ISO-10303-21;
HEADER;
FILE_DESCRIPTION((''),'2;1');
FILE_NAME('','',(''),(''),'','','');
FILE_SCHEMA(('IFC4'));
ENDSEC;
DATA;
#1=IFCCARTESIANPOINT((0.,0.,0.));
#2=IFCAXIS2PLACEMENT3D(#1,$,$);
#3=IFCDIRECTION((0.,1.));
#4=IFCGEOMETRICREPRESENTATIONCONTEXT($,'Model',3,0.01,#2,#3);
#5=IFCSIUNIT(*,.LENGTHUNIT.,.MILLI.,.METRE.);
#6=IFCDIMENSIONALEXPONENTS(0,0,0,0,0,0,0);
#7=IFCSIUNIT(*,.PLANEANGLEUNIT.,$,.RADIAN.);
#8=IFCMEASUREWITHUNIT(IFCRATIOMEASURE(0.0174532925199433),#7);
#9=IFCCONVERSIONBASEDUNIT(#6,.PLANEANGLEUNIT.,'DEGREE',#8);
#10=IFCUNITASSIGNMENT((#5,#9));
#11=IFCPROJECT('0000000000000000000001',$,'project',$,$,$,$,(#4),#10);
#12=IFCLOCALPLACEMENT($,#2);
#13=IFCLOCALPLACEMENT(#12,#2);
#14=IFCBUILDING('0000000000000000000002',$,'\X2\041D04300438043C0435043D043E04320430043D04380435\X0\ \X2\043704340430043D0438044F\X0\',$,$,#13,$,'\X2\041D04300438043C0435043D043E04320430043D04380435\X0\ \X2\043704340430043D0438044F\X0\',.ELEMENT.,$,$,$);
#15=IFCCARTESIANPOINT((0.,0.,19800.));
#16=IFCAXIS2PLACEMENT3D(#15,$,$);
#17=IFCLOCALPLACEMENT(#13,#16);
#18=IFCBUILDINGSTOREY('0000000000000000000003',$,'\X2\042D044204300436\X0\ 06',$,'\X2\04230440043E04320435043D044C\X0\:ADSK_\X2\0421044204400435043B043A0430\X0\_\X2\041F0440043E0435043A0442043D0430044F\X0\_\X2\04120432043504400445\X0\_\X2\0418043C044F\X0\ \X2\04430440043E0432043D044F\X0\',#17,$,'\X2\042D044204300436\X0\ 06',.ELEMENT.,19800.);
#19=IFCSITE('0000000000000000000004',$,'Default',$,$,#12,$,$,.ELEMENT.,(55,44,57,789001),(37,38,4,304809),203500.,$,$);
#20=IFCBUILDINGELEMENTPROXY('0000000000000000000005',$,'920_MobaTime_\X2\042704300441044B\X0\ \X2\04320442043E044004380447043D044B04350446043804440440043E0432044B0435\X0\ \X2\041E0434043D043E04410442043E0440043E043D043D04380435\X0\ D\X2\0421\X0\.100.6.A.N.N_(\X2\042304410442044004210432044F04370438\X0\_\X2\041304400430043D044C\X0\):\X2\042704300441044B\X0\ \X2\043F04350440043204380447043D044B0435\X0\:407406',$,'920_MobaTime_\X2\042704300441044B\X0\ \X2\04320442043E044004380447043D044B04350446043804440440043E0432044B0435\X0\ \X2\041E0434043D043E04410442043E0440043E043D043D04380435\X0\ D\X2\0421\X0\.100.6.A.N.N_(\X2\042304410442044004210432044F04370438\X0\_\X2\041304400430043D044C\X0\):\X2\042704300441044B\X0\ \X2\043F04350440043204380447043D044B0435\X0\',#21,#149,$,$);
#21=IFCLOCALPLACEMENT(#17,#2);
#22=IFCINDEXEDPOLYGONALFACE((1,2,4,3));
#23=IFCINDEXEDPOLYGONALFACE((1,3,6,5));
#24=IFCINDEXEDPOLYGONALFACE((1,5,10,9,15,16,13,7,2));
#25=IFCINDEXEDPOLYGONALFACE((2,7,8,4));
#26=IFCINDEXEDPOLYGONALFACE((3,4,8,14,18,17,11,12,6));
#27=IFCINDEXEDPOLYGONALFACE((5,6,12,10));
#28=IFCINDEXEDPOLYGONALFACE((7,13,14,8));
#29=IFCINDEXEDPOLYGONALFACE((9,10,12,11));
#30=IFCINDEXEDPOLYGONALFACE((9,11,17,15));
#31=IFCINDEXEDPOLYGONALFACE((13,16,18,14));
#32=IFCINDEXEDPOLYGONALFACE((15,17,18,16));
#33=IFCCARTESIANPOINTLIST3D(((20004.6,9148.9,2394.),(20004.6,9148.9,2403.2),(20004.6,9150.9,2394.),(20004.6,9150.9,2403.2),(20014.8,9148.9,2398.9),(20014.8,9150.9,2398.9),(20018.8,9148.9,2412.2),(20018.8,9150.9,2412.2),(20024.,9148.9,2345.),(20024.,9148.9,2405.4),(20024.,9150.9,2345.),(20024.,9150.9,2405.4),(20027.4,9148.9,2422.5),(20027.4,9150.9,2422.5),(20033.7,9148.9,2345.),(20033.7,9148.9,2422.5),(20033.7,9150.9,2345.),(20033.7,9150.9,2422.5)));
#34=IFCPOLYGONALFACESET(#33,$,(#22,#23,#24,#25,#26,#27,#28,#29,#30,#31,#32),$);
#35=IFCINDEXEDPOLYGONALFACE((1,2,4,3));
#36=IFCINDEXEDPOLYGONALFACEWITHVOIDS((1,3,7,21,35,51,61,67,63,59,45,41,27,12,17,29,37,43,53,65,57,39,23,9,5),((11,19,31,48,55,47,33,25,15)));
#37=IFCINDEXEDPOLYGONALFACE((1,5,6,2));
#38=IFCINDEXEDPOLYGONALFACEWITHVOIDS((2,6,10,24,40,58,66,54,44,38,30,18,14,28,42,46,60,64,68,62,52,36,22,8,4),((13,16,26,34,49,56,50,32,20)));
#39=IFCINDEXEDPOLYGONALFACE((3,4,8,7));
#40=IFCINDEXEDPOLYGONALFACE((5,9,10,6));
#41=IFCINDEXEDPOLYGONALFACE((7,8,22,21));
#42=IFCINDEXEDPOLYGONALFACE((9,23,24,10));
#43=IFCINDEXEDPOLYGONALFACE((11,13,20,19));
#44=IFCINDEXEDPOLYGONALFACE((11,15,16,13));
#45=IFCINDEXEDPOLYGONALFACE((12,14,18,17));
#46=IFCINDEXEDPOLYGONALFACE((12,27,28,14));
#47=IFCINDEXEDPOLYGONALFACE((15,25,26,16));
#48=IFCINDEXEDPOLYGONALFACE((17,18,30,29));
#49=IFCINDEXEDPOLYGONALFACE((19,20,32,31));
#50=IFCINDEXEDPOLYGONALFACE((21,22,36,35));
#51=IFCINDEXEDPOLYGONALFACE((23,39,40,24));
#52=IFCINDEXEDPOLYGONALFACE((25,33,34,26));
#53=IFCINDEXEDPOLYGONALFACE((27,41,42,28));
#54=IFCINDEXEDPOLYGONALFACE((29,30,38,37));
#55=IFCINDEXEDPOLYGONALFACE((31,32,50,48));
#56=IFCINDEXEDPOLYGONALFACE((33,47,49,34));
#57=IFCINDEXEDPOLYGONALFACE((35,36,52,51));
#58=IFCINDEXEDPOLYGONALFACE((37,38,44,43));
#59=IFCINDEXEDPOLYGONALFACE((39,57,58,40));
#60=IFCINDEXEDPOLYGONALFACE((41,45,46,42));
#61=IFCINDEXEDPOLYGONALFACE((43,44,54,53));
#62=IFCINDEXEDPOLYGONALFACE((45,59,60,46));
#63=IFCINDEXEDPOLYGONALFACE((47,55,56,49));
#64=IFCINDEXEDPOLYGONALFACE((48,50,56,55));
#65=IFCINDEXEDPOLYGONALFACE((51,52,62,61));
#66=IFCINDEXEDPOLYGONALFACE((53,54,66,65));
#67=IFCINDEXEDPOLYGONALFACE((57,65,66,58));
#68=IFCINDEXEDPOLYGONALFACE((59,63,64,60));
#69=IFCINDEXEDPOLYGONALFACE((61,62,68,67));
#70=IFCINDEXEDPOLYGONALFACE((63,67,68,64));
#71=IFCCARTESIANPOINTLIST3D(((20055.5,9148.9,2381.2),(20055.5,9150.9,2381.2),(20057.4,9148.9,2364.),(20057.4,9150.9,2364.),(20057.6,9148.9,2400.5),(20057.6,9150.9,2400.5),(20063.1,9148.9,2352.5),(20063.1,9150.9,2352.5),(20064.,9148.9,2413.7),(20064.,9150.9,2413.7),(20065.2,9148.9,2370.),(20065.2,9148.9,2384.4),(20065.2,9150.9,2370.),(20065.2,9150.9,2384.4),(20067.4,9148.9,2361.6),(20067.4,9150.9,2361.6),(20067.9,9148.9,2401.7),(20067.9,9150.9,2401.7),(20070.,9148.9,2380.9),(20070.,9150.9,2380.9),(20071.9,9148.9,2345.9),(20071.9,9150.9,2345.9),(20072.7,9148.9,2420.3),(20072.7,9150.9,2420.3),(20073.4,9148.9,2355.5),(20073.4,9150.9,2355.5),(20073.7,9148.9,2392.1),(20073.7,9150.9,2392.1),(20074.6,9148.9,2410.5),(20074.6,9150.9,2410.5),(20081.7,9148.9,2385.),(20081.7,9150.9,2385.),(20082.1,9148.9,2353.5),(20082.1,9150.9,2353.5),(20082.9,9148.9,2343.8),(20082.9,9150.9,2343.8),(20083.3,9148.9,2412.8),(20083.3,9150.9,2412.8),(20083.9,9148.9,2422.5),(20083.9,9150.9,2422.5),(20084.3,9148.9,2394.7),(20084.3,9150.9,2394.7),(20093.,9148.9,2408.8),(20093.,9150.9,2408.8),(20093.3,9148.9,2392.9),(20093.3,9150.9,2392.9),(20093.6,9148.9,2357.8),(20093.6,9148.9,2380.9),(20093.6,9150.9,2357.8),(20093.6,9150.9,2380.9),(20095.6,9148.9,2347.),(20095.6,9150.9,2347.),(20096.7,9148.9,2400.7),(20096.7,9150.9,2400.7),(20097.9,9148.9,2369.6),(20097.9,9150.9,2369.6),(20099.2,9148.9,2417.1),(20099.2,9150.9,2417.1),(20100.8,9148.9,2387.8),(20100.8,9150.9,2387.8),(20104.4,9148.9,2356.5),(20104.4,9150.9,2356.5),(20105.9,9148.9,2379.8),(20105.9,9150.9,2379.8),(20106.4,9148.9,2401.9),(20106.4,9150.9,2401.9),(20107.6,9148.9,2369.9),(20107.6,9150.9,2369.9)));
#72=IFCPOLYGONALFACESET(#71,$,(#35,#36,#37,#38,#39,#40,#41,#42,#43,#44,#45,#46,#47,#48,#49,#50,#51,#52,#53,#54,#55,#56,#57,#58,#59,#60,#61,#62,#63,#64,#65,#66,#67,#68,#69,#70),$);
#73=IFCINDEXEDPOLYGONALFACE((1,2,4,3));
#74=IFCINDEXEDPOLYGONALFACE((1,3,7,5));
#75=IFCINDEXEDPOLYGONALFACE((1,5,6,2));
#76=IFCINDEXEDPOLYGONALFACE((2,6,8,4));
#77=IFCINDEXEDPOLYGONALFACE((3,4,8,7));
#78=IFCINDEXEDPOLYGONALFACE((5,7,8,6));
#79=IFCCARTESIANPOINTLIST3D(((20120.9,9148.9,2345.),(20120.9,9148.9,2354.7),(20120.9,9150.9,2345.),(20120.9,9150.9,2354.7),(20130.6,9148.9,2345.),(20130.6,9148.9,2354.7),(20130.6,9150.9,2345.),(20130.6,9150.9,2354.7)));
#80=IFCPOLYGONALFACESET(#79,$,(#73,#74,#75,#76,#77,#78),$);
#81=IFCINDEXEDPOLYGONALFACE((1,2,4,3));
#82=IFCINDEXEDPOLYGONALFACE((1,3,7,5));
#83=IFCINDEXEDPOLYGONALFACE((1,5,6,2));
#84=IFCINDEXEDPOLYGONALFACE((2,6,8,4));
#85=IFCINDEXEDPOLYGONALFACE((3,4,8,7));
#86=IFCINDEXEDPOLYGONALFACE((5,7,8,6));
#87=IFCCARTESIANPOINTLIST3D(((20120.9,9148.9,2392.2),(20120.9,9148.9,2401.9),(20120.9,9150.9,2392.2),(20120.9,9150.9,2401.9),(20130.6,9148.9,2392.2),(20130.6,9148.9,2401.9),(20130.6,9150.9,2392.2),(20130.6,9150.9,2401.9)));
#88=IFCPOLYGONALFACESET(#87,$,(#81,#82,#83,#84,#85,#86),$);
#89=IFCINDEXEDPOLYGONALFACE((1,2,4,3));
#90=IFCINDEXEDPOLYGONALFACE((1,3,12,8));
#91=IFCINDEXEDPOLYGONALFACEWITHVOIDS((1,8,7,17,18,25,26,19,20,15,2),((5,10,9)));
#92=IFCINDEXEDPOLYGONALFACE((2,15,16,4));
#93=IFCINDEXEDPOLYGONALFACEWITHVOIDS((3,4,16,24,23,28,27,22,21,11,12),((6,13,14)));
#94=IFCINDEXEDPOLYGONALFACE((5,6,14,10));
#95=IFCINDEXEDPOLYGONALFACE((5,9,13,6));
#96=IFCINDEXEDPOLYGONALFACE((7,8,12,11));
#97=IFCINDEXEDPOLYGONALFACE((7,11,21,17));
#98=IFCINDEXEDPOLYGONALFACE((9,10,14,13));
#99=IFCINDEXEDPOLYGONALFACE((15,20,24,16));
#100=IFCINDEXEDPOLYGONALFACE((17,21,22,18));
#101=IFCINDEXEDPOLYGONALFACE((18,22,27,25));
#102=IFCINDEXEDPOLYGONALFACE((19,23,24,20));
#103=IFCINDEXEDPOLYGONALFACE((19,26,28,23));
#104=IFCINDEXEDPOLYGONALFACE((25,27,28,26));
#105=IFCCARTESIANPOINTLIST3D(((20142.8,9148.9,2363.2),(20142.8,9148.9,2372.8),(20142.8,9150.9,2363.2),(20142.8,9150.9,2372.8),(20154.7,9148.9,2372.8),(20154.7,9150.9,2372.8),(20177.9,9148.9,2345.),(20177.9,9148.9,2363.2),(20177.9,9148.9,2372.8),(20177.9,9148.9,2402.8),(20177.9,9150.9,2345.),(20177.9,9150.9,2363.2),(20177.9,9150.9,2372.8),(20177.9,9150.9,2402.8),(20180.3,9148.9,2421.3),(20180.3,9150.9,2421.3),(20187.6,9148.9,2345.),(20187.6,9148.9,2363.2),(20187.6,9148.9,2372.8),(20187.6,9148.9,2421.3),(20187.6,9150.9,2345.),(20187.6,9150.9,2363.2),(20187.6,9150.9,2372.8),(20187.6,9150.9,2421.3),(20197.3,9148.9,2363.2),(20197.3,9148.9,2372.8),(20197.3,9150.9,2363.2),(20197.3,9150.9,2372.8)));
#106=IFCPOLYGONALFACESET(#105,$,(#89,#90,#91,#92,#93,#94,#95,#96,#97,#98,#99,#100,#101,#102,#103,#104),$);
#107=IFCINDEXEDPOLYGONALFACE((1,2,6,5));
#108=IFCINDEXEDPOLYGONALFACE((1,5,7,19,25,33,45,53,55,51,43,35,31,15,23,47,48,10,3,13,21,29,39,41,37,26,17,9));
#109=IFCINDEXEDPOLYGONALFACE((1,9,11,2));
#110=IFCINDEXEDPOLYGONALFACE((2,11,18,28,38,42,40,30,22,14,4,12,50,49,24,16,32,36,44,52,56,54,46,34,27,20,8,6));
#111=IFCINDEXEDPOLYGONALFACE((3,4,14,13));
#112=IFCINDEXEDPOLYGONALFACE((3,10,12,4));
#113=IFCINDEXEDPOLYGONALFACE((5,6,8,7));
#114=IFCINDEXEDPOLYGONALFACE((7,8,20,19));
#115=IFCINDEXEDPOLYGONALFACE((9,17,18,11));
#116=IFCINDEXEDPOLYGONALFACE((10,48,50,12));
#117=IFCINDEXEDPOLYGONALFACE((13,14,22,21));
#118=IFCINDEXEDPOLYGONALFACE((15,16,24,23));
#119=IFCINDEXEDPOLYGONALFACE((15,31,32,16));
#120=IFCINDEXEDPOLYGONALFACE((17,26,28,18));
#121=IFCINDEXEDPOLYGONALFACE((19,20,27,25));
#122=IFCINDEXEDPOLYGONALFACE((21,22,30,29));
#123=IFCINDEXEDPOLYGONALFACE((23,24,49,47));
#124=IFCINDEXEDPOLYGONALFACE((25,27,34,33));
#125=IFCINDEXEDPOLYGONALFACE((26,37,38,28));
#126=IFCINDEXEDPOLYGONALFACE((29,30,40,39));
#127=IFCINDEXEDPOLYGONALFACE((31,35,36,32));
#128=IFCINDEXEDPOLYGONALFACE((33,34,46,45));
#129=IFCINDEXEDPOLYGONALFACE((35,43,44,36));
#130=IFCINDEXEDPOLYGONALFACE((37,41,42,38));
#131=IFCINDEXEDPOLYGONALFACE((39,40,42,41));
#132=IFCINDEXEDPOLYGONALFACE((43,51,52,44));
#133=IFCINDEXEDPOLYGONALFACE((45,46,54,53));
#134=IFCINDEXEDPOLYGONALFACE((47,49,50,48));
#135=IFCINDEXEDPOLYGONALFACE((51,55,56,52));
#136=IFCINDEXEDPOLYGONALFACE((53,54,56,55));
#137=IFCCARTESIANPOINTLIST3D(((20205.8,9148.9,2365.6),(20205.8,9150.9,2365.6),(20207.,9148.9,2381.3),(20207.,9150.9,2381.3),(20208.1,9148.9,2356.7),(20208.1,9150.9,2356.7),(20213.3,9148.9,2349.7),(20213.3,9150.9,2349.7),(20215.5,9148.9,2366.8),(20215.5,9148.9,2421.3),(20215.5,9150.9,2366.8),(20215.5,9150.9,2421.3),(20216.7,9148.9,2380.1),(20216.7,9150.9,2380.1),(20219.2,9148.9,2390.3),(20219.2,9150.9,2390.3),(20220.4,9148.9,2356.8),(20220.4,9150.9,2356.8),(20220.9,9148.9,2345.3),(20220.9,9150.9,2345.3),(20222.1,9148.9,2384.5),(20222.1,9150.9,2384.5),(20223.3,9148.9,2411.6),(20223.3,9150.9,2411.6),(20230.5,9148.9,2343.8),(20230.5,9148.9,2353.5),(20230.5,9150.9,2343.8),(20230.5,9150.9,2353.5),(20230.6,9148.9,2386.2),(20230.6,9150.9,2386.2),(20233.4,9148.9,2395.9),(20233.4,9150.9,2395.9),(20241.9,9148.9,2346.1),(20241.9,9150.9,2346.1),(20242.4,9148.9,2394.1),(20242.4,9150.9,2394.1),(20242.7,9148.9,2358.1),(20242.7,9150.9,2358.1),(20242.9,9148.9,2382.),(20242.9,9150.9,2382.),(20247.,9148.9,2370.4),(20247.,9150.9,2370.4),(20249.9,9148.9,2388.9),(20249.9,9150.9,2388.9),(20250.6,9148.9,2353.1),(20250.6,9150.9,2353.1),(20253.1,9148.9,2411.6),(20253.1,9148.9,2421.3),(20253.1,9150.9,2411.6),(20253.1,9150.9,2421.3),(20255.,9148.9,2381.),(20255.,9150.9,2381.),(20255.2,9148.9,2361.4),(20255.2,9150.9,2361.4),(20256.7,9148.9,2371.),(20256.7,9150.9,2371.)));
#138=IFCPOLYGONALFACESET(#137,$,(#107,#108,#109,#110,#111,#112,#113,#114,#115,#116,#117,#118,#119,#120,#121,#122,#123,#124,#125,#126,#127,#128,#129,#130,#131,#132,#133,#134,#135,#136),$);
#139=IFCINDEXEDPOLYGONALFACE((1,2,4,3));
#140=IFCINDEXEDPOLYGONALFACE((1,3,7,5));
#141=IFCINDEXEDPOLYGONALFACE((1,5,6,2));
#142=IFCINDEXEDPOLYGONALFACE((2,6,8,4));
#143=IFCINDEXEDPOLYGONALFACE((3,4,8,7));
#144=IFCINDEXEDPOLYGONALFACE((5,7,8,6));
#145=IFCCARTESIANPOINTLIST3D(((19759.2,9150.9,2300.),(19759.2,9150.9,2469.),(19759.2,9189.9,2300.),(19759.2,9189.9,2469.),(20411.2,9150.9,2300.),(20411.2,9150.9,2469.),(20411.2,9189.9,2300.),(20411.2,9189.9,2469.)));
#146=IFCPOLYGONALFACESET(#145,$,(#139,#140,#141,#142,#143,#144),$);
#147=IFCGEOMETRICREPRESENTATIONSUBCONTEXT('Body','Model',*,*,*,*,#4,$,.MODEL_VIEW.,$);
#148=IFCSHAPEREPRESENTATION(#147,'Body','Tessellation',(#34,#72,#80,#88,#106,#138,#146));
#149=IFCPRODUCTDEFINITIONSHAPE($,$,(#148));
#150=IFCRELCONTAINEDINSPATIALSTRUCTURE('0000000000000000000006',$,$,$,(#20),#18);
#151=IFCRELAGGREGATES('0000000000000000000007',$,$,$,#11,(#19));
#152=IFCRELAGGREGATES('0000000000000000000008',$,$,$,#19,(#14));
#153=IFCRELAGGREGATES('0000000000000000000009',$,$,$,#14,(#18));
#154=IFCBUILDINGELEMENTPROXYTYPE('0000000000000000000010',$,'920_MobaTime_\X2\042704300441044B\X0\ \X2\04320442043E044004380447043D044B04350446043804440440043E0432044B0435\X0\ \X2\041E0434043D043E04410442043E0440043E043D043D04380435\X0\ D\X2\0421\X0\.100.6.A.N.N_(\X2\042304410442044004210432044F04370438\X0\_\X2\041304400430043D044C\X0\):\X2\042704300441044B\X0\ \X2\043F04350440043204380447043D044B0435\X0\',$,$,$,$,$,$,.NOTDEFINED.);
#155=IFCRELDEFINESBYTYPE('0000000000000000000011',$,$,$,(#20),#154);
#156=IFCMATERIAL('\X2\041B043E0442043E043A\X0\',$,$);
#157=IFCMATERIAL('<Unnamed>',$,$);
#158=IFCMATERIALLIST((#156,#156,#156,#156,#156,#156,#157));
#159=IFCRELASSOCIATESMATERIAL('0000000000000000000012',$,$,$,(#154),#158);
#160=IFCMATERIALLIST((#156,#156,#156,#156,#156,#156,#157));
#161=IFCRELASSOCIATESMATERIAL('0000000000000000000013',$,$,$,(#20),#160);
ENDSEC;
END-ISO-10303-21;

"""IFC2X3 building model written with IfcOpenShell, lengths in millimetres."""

from ifc_helpers import new_model, entity, si_unit, converted_unit, direction, frame, origin, origin_2d_with_axis, place, context, subcontext, project, spatial, polyline, rectangle, outline, extrude, source, transform, mapped, material, material_list, type_object, type_shapes, element, save


model = new_model("IFC2X3")

# Units and contexts
model_context = context("Model", 3, precision=0.01, world=origin(), true_north=direction((0.0, 1.0)))
body_context = subcontext(model_context, "Body", "Model", "MODEL_VIEW")
ifc_project = project(units=[si_unit("LENGTHUNIT", "METRE", prefix="MILLI"), converted_unit("PLANEANGLEUNIT", "DEGREE", entity("IfcRatioMeasure", 0.0174532925199433), si_unit("PLANEANGLEUNIT", "RADIAN"), dimensions=[0, 0, 0, 0, 0, 0, 0])], contexts=[model_context])

# Site, building, storey
site_placement = place(None, frame((0.0, 0.0, 0.0)))
site = spatial("IfcSite", under=ifc_project, at=site_placement, Name="Default", CompositionType="ELEMENT", RefLatitude=(55, 44, 57, 789001), RefLongitude=(37, 38, 4, 304809), RefElevation=203500.0)
building_placement = place(site_placement, origin())
building = spatial("IfcBuilding", under=site, at=building_placement, Name="Наименование здания", LongName="Наименование здания", CompositionType="ELEMENT")
storey_placement = place(building_placement, frame((0.0, 0.0, 19800.0)))
storey = spatial("IfcBuildingStorey", under=building, at=storey_placement, Name="Этаж 06", ObjectType="Уровень:ADSK_Стрелка_Проектная_Вверх_Имя уровня", LongName="Этаж 06", CompositionType="ELEMENT", Elevation=19800.0)

# Building element proxy
ifc_material_1 = material(Name="Лоток")
ifc_material_2 = material(Name="<Unnamed>")
ifc_material_list_1 = material_list([ifc_material_1, ifc_material_1, ifc_material_1, ifc_material_1, ifc_material_1, ifc_material_1, ifc_material_2])
ifc_material_list_2 = material_list([ifc_material_1, ifc_material_1, ifc_material_1, ifc_material_1, ifc_material_1, ifc_material_1, ifc_material_2])
building_element_proxy_type_1 = type_object("IfcBuildingElementProxyType", Name="920_MobaTime_Часы вторичныецифровые Односторонние DС.100.6.A.N.N_(УстрСвязи_Грань):Часы первичные", PredefinedType="NOTDEFINED", material=ifc_material_list_2)
shared_shape_1 = source(origin(), body_context, "Body", "SweptSolid", [
    extrude(outline(polyline([(-49.3, -13.1), (28.2, -13.1), (28.2, -6.8), (17.9, 1.8), (8.9, 16.0), (-0.3, 16.0), (4.6, 5.8), (11.1, -3.4), (-49.3, -3.4), (-49.3, -13.1)])), frame((-64.6, 9.8, 39.0), z_axis=(0.0, 0.0, 1.0), x_axis=(0.0, 1.0, 0.0)), (0.0, 0.0, 1.0), 2.0),
    extrude(outline(polyline([(2.2, -27.6), (19.0, -27.6), (30.5, -16.1), (33.3, -4.9), (31.0, 5.8), (21.8, 17.2), (5.2, 27.3), (-11.1, 33.0), (-24.0, 32.7), (-33.6, 27.6), (-40.3, 18.6), (-42.8, 5.7), (-38.0, -6.3), (-27.2, -15.0), (-17.5, -17.7), (-8.2, -16.4), (-0.3, -11.9), (5.1, -4.5), (7.3, 6.2), (4.0, 17.2), (18.5, 7.3), (23.6, -2.4), (22.0, -11.4), (14.2, -18.4), (5.3, -18.3), (2.2, -27.6)]), holes=[polyline([(-9.0, 23.3), (-1.3, 14.4), (-2.6, 2.0), (-11.4, -7.0), (-23.4, -6.1), (-32.2, 2.9), (-31.2, 15.1), (-25.6, 22.1), (-17.5, 24.9), (-9.0, 23.3)])]), frame((-2.7, 3.6, 39.0), z_axis=(0.0, 0.0, 1.0), x_axis=(-0.427649, 0.903945, 0.0)), (0.0, 0.0, 1.0), 2.0),
    extrude(rectangle(XDim=9.7, YDim=9.7, at=origin_2d_with_axis()), frame((40.6, -34.7, 39.0)), (0.0, 0.0, 1.0), 2.0),
    extrude(rectangle(XDim=9.7, YDim=9.7, at=origin_2d_with_axis()), frame((40.6, 12.6, 39.0)), (0.0, 0.0, 1.0), 2.0),
    extrude(outline(polyline([(-0.9, -28.1), (8.8, -28.1), (8.8, -9.9), (18.5, -9.9), (18.5, -0.2), (8.8, -0.2), (8.8, 48.3), (1.5, 48.3), (-36.0, -0.2), (-36.0, -9.9), (-0.9, -9.9), (-0.9, -28.1)]), holes=[polyline([(-0.9, -0.2), (-24.1, -0.2), (-0.9, 29.7), (-0.9, -0.2)])]), frame((93.6, -11.4, 39.0)), (0.0, 0.0, 1.0), 2.0),
    extrude(outline(polyline([(3.3, -28.3), (12.5, -28.3), (20.5, -25.0), (26.8, -18.8), (30.7, -10.0), (31.4, 1.6), (26.9, 11.8), (20.1, 18.4), (11.1, 22.3), (1.0, 23.3), (-7.9, 20.4), (-14.9, 14.5), (-18.9, 6.2), (-17.1, -9.0), (-36.7, 0.5), (-29.1, 29.3), (-38.5, 31.7), (-48.1, -4.6), (-11.6, -23.0), (-8.0, -14.0), (-10.8, -7.6), (-10.2, 1.1), (-3.0, 11.8), (9.2, 12.8), (20.0, 5.4), (21.3, -7.5), (15.5, -16.4), (4.6, -18.6), (3.3, -28.3)])), frame((147.1, -8.5, 39.0), z_axis=(0.0, 0.0, 1.0), x_axis=(0.256974, -0.966418, 0.0)), (0.0, 0.0, 1.0), 2.0),
    extrude(rectangle(XDim=652.0, YDim=169.0, at=origin_2d_with_axis()), frame((0.0, 0.0, 0.0), z_axis=(0.0, 0.0, 1.0), x_axis=(-1.0, 0.0, 0.0)), (0.0, 0.0, 1.0), 39.0),
])
type_shapes(building_element_proxy_type_1, [shared_shape_1])
proxy_1_placement = place(storey_placement, frame((20085.2, 9189.9, 2384.5), z_axis=(0.0, -1.0, 0.0), x_axis=(1.0, 0.0, 0.0)))
element("IfcBuildingElementProxy", 1, at=proxy_1_placement, inside=storey, type_object=building_element_proxy_type_1, material=ifc_material_list_1, Name="920_MobaTime_Часы вторичныецифровые Односторонние DС.100.6.A.N.N_(УстрСвязи_Грань):Часы первичные:407406", ObjectType="920_MobaTime_Часы вторичныецифровые Односторонние DС.100.6.A.N.N_(УстрСвязи_Грань):Часы первичные", context=body_context, shape_type="MappedRepresentation", body=[
    mapped(shared_shape_1, transform((0.0, 0.0, 0.0), scale=1.0)),
])

save(model, "model.ifc")
